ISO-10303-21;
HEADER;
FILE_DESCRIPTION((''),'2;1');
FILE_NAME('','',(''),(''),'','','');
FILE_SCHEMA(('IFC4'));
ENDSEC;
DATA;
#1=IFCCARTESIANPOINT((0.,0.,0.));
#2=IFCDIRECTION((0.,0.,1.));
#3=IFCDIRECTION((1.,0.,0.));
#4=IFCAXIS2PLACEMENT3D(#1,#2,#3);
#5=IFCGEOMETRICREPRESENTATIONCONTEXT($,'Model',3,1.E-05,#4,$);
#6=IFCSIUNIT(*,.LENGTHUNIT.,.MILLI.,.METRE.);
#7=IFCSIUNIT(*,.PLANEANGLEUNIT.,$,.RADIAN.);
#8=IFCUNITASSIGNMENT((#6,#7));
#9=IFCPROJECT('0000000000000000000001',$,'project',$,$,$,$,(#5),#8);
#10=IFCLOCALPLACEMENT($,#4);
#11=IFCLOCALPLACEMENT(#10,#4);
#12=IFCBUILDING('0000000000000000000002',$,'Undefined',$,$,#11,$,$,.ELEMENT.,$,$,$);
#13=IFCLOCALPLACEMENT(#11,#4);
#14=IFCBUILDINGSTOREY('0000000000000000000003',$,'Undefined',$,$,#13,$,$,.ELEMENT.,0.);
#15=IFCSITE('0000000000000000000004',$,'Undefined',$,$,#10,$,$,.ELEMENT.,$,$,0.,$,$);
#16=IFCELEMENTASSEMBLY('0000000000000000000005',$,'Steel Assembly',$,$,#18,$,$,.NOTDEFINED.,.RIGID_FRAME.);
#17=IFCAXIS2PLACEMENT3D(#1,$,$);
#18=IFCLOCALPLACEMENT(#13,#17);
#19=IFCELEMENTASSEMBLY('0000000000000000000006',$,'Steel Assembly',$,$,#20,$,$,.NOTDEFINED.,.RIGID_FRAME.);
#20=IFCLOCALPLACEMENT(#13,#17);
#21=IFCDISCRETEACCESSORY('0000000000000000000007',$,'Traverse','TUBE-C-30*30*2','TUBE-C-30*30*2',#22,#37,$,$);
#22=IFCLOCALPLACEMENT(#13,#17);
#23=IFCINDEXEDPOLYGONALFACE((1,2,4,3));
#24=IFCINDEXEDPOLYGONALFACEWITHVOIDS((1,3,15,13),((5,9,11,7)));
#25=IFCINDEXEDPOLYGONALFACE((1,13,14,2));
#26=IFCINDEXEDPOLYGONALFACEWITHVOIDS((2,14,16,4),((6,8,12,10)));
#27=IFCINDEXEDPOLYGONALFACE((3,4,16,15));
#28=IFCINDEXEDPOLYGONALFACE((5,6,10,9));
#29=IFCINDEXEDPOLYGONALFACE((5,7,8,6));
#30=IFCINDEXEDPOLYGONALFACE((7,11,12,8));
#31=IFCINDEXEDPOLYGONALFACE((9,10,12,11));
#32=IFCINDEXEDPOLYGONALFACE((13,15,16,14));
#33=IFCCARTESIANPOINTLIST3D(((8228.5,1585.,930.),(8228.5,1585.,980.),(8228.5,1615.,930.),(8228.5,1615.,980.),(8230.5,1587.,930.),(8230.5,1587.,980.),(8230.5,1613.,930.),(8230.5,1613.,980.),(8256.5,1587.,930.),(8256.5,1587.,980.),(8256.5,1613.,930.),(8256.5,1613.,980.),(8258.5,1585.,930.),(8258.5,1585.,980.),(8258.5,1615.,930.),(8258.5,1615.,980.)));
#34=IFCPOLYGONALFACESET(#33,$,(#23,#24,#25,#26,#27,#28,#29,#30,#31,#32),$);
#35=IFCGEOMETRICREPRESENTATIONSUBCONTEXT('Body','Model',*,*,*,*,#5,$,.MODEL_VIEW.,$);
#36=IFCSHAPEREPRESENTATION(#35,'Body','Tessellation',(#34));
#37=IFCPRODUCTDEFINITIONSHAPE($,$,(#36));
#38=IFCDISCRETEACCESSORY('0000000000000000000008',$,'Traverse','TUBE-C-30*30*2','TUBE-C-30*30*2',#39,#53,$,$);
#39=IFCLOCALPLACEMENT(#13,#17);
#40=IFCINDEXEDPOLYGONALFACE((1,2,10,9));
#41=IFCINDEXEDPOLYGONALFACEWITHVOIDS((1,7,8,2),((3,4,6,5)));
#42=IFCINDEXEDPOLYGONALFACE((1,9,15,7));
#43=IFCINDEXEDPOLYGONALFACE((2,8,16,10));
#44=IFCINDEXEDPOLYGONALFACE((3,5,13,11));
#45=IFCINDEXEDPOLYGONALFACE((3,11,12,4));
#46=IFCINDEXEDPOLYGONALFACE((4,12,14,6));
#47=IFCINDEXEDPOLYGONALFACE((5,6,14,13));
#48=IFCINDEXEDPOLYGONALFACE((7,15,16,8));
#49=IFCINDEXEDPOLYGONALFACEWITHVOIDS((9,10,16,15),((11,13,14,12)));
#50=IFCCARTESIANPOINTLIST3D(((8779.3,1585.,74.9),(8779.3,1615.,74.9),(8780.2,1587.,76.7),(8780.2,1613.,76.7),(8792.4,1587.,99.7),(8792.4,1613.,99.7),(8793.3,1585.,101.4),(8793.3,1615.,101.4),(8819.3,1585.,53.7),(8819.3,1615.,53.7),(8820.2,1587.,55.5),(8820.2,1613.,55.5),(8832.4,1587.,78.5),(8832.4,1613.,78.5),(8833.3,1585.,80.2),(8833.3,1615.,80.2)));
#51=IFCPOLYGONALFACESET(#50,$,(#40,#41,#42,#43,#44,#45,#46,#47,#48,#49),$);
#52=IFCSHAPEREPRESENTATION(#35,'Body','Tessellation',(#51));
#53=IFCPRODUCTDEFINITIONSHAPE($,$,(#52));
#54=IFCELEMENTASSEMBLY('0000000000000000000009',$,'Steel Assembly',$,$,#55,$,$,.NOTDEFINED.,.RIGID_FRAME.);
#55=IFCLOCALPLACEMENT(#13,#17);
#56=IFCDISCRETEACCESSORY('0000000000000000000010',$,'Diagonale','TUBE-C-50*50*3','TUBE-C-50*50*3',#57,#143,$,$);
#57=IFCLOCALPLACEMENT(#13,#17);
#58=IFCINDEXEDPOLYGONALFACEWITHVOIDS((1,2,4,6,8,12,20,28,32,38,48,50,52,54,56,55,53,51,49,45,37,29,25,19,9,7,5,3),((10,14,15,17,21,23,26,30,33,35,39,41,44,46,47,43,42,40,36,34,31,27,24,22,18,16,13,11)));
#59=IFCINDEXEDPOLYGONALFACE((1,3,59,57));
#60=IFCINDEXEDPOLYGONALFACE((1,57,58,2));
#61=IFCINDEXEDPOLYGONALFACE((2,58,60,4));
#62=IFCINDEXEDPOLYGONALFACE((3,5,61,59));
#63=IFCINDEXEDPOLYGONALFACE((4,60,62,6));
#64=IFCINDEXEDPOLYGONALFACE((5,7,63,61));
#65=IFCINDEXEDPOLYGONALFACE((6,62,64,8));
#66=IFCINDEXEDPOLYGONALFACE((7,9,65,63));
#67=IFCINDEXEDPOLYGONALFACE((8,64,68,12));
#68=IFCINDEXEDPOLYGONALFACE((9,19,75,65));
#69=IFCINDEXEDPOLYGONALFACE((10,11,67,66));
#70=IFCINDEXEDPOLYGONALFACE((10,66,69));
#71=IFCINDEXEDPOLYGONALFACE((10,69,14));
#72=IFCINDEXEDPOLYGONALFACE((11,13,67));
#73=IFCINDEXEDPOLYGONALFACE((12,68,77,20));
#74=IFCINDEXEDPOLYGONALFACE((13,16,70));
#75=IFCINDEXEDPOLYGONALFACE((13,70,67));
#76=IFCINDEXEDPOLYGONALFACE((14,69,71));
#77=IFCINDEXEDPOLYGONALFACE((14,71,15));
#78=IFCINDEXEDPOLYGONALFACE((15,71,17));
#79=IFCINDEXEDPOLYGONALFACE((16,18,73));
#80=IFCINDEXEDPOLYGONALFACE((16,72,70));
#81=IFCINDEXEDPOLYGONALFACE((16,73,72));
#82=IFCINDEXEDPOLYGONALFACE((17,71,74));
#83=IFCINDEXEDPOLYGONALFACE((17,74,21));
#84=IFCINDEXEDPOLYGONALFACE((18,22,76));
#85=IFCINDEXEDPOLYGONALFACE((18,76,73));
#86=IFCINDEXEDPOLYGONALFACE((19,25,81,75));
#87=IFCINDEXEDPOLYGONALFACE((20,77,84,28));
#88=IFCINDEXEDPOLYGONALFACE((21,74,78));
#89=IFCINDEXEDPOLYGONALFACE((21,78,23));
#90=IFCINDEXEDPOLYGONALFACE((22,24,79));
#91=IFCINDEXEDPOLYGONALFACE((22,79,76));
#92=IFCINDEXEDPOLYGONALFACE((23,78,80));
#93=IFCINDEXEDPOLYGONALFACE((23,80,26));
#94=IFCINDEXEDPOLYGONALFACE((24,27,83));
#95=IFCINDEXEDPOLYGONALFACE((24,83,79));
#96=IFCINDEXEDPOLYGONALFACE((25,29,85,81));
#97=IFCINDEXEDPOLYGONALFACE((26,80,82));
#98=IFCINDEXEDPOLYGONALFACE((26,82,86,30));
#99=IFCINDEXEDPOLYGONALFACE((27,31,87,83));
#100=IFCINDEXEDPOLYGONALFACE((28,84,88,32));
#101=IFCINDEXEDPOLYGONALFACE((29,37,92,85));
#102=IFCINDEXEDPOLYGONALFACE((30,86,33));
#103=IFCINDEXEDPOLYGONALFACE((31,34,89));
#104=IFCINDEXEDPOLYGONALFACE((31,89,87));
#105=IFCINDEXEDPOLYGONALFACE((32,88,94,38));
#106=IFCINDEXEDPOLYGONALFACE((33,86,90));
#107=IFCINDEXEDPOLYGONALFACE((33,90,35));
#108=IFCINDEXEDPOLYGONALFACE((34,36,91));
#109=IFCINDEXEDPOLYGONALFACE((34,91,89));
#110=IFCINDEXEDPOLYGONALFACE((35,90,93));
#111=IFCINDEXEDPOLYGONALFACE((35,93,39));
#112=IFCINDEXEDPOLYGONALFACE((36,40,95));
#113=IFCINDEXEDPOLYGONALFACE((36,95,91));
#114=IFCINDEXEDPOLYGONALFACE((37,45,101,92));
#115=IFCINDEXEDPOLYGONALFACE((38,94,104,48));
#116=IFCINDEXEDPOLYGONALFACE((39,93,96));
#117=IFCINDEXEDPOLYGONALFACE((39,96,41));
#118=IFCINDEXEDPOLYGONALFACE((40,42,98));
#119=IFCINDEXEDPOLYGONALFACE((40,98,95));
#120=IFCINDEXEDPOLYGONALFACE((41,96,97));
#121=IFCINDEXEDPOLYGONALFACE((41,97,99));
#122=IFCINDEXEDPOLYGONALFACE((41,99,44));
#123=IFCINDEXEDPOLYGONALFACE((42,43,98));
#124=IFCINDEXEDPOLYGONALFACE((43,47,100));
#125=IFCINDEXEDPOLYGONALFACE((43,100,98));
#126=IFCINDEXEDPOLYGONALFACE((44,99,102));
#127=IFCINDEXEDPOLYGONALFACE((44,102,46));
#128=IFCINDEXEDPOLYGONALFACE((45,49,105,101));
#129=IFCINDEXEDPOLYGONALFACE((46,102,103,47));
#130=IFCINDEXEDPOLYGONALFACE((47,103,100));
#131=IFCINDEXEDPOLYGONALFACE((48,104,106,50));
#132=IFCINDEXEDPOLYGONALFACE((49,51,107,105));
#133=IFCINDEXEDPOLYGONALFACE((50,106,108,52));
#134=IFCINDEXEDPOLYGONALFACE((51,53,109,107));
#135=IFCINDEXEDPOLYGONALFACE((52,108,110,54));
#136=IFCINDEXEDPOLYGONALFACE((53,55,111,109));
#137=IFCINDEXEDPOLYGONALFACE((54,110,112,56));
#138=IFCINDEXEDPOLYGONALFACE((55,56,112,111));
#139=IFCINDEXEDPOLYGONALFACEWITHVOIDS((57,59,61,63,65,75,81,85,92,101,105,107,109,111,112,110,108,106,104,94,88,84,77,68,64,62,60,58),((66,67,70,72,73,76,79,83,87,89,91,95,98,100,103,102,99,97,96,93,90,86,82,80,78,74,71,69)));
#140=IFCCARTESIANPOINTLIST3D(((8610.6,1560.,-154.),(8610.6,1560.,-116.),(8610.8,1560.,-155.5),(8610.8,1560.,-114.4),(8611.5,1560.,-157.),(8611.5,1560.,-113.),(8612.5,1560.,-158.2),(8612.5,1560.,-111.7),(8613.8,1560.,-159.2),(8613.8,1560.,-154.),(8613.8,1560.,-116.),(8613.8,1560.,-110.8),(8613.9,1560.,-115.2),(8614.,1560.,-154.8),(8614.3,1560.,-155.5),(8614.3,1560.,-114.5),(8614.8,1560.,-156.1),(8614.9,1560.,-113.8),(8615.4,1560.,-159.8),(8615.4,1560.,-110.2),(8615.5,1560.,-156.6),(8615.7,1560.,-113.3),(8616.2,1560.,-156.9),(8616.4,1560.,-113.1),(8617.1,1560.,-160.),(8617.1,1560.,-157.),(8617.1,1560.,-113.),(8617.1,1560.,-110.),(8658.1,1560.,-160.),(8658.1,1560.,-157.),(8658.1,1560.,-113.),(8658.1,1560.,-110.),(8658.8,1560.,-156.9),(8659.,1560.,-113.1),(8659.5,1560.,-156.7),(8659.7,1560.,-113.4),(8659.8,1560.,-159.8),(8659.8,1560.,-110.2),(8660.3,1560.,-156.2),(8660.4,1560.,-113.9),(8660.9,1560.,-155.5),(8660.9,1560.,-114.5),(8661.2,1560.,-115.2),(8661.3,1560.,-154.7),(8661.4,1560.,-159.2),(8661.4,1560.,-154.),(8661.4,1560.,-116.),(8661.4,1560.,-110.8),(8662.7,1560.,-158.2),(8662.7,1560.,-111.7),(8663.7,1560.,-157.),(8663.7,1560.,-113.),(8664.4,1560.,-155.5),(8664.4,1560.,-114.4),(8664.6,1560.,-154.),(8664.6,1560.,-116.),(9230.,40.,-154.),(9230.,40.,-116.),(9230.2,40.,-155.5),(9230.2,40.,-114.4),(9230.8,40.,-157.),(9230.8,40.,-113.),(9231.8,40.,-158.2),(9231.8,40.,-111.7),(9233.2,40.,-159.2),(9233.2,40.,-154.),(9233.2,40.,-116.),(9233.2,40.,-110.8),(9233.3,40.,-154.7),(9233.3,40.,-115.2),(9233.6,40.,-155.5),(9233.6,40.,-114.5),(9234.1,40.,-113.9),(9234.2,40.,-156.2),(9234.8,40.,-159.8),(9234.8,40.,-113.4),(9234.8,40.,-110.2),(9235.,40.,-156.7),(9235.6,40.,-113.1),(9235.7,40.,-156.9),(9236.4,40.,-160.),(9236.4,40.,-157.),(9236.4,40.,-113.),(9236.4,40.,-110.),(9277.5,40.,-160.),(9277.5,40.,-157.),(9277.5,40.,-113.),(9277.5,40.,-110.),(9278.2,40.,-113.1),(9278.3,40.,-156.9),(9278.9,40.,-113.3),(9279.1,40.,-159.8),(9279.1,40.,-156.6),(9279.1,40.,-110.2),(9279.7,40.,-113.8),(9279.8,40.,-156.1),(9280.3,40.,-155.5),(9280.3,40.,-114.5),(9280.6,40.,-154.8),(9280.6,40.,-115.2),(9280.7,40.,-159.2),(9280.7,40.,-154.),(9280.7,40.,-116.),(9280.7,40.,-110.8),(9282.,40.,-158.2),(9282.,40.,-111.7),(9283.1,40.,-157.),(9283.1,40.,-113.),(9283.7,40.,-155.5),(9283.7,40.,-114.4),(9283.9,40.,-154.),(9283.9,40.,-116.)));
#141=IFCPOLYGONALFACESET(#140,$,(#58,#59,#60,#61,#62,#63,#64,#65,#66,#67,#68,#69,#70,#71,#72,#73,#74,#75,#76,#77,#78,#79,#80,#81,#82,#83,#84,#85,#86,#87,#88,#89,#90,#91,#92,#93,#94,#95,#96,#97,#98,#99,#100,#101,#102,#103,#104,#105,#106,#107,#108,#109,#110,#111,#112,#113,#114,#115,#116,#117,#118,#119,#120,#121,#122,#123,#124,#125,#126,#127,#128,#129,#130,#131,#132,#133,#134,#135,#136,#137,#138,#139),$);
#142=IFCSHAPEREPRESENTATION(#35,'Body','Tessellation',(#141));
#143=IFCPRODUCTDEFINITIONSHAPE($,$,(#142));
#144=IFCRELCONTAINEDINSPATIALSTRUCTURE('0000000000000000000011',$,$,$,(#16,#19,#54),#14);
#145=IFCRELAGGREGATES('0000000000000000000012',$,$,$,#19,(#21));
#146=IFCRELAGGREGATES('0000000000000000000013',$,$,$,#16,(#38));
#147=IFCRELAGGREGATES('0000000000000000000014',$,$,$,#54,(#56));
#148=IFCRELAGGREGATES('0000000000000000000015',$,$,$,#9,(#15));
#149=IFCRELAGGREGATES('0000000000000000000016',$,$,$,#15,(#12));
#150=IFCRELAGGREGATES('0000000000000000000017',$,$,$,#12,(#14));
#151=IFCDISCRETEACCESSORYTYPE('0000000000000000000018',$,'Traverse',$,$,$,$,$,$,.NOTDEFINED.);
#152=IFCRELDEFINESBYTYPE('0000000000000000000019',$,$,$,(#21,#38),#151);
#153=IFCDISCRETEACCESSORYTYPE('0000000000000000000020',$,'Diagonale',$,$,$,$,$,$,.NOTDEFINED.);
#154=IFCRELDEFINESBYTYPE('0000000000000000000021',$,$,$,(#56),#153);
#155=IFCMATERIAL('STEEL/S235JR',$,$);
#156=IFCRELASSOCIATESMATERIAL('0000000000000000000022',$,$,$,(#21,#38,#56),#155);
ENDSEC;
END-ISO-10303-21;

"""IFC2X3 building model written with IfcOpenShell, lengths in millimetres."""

from ifc_helpers import new_model, si_unit, frame, origin_with_axes, origin_2d_with_axis, place, context, subcontext, project, spatial, hollow_rectangle, extrude, clip, halfspace, material, type_object, element, aggregate, save


model = new_model("IFC2X3")

# Units and contexts
model_context = context("Model", 3, precision=1e-05, world=origin_with_axes())
body_context = subcontext(model_context, "Body", "Model", "MODEL_VIEW")
ifc_project = project(units=[si_unit("LENGTHUNIT", "METRE", prefix="MILLI"), si_unit("PLANEANGLEUNIT", "RADIAN")], contexts=[model_context])

# Site, building, storey
site_placement = place(None, origin_with_axes())
site = spatial("IfcSite", under=ifc_project, at=site_placement, Name="Undefined", CompositionType="ELEMENT", RefElevation=0.0)
building_placement = place(site_placement, origin_with_axes())
building = spatial("IfcBuilding", under=site, at=building_placement, Name="Undefined", CompositionType="ELEMENT")
storey_placement = place(building_placement, origin_with_axes())
storey = spatial("IfcBuildingStorey", under=building, at=storey_placement, Name="Undefined", CompositionType="ELEMENT", Elevation=0.0)

# Element assembly
assembly_1_placement = place(storey_placement, origin_with_axes())
assembly_1 = element("IfcElementAssembly", 1, at=assembly_1_placement, inside=storey, Name="Steel Assembly", AssemblyPlace="NOTDEFINED", PredefinedType="RIGID_FRAME")
ifc_material = material(Name="STEEL/S235JR")

# Element assembly
assembly_2_placement = place(storey_placement, origin_with_axes())
assembly_2 = element("IfcElementAssembly", 2, at=assembly_2_placement, inside=storey, Name="Steel Assembly", AssemblyPlace="NOTDEFINED", PredefinedType="RIGID_FRAME")

# Discrete accessories
discrete_accessory_type_1 = type_object("IfcDiscreteAccessoryType", Name="Traverse")
discrete_accessory_1_placement = place(assembly_2_placement, frame((8243.5, 1600.0, 930.0), z_axis=(0.0, 0.0, 1.0), x_axis=(1.0, 0.0, 0.0)))
discrete_accessory_1 = element("IfcDiscreteAccessory", 3, at=discrete_accessory_1_placement, type_object=discrete_accessory_type_1, material=ifc_material, Name="Traverse", Description="TUBE-C-30*30*2", ObjectType="TUBE-C-30*30*2", context=body_context, shape_type="SweptSolid", body=[
    extrude(hollow_rectangle(XDim=30.0, YDim=30.0, WallThickness=2.0, at=origin_2d_with_axis()), frame((0.0, 0.0, 50.0), z_axis=(0.0, 0.0, -1.0), x_axis=(-1.0, 0.0, 0.0)), (0.0, 0.0, 1.0), 50.0),
])
aggregate(assembly_2, [discrete_accessory_1])
discrete_accessory_2_placement = place(assembly_1_placement, frame((8826.3, 1600.0, 67.0), z_axis=(-0.000011, 1.0, 0.0), x_axis=(-0.883506, -0.00001, 0.46842)))
discrete_accessory_2 = element("IfcDiscreteAccessory", 4, at=discrete_accessory_2_placement, type_object=discrete_accessory_type_1, material=ifc_material, Name="Traverse", Description="TUBE-C-30*30*2", ObjectType="TUBE-C-30*30*2", context=body_context, shape_type="SweptSolid", body=[
    extrude(hollow_rectangle(XDim=30.0, YDim=30.0, WallThickness=2.0, at=origin_2d_with_axis()), frame((45.3, 0.0, 0.0), z_axis=(-1.0, 0.0, 0.0), x_axis=(0.0, -1.0, 0.0)), (0.0, 0.0, 1.0), 45.3),
])
aggregate(assembly_1, [discrete_accessory_2])

# Element assembly, discrete accessory
assembly_3_placement = place(storey_placement, origin_with_axes())
assembly_3 = element("IfcElementAssembly", 5, at=assembly_3_placement, inside=storey, Name="Steel Assembly", AssemblyPlace="NOTDEFINED", PredefinedType="RIGID_FRAME")
discrete_accessory_type_2 = type_object("IfcDiscreteAccessoryType", Name="Diagonale")
discrete_accessory_3_placement = place(assembly_3_placement, frame((8629.8, 1579.1, -135.0), z_axis=(0.926073, 0.377344, 0.0), x_axis=(0.377344, -0.926073, 0.0)))
discrete_accessory_3 = element("IfcDiscreteAccessory", 6, at=discrete_accessory_3_placement, type_object=discrete_accessory_type_2, material=ifc_material, Name="Diagonale", Description="TUBE-C-50*50*3", ObjectType="TUBE-C-50*50*3", context=body_context, shape_type="Clipping", body=[
    clip(clip(extrude(hollow_rectangle(XDim=50.0, YDim=50.0, WallThickness=3.0, InnerFilletRadius=3.0, OuterFilletRadius=6.0, at=origin_2d_with_axis()), frame((1682.5, 0.0, 0.0), z_axis=(-1.0, 0.0, 0.0), x_axis=(0.0, -1.0, 0.0)), (0.0, 0.0, 1.0), 1682.5), halfspace(frame((10.4, 25.0, -25.0), z_axis=(-0.926073, 0.0, 0.377344), x_axis=(0.377344, 0.0, 0.926073)), False)), halfspace(frame((1651.7, -25.0, -25.0), z_axis=(0.926073, 0.0, -0.377344), x_axis=(0.377344, 0.0, 0.926073)), False)),
])
aggregate(assembly_3, [discrete_accessory_3])

save(model, "model.ifc")
